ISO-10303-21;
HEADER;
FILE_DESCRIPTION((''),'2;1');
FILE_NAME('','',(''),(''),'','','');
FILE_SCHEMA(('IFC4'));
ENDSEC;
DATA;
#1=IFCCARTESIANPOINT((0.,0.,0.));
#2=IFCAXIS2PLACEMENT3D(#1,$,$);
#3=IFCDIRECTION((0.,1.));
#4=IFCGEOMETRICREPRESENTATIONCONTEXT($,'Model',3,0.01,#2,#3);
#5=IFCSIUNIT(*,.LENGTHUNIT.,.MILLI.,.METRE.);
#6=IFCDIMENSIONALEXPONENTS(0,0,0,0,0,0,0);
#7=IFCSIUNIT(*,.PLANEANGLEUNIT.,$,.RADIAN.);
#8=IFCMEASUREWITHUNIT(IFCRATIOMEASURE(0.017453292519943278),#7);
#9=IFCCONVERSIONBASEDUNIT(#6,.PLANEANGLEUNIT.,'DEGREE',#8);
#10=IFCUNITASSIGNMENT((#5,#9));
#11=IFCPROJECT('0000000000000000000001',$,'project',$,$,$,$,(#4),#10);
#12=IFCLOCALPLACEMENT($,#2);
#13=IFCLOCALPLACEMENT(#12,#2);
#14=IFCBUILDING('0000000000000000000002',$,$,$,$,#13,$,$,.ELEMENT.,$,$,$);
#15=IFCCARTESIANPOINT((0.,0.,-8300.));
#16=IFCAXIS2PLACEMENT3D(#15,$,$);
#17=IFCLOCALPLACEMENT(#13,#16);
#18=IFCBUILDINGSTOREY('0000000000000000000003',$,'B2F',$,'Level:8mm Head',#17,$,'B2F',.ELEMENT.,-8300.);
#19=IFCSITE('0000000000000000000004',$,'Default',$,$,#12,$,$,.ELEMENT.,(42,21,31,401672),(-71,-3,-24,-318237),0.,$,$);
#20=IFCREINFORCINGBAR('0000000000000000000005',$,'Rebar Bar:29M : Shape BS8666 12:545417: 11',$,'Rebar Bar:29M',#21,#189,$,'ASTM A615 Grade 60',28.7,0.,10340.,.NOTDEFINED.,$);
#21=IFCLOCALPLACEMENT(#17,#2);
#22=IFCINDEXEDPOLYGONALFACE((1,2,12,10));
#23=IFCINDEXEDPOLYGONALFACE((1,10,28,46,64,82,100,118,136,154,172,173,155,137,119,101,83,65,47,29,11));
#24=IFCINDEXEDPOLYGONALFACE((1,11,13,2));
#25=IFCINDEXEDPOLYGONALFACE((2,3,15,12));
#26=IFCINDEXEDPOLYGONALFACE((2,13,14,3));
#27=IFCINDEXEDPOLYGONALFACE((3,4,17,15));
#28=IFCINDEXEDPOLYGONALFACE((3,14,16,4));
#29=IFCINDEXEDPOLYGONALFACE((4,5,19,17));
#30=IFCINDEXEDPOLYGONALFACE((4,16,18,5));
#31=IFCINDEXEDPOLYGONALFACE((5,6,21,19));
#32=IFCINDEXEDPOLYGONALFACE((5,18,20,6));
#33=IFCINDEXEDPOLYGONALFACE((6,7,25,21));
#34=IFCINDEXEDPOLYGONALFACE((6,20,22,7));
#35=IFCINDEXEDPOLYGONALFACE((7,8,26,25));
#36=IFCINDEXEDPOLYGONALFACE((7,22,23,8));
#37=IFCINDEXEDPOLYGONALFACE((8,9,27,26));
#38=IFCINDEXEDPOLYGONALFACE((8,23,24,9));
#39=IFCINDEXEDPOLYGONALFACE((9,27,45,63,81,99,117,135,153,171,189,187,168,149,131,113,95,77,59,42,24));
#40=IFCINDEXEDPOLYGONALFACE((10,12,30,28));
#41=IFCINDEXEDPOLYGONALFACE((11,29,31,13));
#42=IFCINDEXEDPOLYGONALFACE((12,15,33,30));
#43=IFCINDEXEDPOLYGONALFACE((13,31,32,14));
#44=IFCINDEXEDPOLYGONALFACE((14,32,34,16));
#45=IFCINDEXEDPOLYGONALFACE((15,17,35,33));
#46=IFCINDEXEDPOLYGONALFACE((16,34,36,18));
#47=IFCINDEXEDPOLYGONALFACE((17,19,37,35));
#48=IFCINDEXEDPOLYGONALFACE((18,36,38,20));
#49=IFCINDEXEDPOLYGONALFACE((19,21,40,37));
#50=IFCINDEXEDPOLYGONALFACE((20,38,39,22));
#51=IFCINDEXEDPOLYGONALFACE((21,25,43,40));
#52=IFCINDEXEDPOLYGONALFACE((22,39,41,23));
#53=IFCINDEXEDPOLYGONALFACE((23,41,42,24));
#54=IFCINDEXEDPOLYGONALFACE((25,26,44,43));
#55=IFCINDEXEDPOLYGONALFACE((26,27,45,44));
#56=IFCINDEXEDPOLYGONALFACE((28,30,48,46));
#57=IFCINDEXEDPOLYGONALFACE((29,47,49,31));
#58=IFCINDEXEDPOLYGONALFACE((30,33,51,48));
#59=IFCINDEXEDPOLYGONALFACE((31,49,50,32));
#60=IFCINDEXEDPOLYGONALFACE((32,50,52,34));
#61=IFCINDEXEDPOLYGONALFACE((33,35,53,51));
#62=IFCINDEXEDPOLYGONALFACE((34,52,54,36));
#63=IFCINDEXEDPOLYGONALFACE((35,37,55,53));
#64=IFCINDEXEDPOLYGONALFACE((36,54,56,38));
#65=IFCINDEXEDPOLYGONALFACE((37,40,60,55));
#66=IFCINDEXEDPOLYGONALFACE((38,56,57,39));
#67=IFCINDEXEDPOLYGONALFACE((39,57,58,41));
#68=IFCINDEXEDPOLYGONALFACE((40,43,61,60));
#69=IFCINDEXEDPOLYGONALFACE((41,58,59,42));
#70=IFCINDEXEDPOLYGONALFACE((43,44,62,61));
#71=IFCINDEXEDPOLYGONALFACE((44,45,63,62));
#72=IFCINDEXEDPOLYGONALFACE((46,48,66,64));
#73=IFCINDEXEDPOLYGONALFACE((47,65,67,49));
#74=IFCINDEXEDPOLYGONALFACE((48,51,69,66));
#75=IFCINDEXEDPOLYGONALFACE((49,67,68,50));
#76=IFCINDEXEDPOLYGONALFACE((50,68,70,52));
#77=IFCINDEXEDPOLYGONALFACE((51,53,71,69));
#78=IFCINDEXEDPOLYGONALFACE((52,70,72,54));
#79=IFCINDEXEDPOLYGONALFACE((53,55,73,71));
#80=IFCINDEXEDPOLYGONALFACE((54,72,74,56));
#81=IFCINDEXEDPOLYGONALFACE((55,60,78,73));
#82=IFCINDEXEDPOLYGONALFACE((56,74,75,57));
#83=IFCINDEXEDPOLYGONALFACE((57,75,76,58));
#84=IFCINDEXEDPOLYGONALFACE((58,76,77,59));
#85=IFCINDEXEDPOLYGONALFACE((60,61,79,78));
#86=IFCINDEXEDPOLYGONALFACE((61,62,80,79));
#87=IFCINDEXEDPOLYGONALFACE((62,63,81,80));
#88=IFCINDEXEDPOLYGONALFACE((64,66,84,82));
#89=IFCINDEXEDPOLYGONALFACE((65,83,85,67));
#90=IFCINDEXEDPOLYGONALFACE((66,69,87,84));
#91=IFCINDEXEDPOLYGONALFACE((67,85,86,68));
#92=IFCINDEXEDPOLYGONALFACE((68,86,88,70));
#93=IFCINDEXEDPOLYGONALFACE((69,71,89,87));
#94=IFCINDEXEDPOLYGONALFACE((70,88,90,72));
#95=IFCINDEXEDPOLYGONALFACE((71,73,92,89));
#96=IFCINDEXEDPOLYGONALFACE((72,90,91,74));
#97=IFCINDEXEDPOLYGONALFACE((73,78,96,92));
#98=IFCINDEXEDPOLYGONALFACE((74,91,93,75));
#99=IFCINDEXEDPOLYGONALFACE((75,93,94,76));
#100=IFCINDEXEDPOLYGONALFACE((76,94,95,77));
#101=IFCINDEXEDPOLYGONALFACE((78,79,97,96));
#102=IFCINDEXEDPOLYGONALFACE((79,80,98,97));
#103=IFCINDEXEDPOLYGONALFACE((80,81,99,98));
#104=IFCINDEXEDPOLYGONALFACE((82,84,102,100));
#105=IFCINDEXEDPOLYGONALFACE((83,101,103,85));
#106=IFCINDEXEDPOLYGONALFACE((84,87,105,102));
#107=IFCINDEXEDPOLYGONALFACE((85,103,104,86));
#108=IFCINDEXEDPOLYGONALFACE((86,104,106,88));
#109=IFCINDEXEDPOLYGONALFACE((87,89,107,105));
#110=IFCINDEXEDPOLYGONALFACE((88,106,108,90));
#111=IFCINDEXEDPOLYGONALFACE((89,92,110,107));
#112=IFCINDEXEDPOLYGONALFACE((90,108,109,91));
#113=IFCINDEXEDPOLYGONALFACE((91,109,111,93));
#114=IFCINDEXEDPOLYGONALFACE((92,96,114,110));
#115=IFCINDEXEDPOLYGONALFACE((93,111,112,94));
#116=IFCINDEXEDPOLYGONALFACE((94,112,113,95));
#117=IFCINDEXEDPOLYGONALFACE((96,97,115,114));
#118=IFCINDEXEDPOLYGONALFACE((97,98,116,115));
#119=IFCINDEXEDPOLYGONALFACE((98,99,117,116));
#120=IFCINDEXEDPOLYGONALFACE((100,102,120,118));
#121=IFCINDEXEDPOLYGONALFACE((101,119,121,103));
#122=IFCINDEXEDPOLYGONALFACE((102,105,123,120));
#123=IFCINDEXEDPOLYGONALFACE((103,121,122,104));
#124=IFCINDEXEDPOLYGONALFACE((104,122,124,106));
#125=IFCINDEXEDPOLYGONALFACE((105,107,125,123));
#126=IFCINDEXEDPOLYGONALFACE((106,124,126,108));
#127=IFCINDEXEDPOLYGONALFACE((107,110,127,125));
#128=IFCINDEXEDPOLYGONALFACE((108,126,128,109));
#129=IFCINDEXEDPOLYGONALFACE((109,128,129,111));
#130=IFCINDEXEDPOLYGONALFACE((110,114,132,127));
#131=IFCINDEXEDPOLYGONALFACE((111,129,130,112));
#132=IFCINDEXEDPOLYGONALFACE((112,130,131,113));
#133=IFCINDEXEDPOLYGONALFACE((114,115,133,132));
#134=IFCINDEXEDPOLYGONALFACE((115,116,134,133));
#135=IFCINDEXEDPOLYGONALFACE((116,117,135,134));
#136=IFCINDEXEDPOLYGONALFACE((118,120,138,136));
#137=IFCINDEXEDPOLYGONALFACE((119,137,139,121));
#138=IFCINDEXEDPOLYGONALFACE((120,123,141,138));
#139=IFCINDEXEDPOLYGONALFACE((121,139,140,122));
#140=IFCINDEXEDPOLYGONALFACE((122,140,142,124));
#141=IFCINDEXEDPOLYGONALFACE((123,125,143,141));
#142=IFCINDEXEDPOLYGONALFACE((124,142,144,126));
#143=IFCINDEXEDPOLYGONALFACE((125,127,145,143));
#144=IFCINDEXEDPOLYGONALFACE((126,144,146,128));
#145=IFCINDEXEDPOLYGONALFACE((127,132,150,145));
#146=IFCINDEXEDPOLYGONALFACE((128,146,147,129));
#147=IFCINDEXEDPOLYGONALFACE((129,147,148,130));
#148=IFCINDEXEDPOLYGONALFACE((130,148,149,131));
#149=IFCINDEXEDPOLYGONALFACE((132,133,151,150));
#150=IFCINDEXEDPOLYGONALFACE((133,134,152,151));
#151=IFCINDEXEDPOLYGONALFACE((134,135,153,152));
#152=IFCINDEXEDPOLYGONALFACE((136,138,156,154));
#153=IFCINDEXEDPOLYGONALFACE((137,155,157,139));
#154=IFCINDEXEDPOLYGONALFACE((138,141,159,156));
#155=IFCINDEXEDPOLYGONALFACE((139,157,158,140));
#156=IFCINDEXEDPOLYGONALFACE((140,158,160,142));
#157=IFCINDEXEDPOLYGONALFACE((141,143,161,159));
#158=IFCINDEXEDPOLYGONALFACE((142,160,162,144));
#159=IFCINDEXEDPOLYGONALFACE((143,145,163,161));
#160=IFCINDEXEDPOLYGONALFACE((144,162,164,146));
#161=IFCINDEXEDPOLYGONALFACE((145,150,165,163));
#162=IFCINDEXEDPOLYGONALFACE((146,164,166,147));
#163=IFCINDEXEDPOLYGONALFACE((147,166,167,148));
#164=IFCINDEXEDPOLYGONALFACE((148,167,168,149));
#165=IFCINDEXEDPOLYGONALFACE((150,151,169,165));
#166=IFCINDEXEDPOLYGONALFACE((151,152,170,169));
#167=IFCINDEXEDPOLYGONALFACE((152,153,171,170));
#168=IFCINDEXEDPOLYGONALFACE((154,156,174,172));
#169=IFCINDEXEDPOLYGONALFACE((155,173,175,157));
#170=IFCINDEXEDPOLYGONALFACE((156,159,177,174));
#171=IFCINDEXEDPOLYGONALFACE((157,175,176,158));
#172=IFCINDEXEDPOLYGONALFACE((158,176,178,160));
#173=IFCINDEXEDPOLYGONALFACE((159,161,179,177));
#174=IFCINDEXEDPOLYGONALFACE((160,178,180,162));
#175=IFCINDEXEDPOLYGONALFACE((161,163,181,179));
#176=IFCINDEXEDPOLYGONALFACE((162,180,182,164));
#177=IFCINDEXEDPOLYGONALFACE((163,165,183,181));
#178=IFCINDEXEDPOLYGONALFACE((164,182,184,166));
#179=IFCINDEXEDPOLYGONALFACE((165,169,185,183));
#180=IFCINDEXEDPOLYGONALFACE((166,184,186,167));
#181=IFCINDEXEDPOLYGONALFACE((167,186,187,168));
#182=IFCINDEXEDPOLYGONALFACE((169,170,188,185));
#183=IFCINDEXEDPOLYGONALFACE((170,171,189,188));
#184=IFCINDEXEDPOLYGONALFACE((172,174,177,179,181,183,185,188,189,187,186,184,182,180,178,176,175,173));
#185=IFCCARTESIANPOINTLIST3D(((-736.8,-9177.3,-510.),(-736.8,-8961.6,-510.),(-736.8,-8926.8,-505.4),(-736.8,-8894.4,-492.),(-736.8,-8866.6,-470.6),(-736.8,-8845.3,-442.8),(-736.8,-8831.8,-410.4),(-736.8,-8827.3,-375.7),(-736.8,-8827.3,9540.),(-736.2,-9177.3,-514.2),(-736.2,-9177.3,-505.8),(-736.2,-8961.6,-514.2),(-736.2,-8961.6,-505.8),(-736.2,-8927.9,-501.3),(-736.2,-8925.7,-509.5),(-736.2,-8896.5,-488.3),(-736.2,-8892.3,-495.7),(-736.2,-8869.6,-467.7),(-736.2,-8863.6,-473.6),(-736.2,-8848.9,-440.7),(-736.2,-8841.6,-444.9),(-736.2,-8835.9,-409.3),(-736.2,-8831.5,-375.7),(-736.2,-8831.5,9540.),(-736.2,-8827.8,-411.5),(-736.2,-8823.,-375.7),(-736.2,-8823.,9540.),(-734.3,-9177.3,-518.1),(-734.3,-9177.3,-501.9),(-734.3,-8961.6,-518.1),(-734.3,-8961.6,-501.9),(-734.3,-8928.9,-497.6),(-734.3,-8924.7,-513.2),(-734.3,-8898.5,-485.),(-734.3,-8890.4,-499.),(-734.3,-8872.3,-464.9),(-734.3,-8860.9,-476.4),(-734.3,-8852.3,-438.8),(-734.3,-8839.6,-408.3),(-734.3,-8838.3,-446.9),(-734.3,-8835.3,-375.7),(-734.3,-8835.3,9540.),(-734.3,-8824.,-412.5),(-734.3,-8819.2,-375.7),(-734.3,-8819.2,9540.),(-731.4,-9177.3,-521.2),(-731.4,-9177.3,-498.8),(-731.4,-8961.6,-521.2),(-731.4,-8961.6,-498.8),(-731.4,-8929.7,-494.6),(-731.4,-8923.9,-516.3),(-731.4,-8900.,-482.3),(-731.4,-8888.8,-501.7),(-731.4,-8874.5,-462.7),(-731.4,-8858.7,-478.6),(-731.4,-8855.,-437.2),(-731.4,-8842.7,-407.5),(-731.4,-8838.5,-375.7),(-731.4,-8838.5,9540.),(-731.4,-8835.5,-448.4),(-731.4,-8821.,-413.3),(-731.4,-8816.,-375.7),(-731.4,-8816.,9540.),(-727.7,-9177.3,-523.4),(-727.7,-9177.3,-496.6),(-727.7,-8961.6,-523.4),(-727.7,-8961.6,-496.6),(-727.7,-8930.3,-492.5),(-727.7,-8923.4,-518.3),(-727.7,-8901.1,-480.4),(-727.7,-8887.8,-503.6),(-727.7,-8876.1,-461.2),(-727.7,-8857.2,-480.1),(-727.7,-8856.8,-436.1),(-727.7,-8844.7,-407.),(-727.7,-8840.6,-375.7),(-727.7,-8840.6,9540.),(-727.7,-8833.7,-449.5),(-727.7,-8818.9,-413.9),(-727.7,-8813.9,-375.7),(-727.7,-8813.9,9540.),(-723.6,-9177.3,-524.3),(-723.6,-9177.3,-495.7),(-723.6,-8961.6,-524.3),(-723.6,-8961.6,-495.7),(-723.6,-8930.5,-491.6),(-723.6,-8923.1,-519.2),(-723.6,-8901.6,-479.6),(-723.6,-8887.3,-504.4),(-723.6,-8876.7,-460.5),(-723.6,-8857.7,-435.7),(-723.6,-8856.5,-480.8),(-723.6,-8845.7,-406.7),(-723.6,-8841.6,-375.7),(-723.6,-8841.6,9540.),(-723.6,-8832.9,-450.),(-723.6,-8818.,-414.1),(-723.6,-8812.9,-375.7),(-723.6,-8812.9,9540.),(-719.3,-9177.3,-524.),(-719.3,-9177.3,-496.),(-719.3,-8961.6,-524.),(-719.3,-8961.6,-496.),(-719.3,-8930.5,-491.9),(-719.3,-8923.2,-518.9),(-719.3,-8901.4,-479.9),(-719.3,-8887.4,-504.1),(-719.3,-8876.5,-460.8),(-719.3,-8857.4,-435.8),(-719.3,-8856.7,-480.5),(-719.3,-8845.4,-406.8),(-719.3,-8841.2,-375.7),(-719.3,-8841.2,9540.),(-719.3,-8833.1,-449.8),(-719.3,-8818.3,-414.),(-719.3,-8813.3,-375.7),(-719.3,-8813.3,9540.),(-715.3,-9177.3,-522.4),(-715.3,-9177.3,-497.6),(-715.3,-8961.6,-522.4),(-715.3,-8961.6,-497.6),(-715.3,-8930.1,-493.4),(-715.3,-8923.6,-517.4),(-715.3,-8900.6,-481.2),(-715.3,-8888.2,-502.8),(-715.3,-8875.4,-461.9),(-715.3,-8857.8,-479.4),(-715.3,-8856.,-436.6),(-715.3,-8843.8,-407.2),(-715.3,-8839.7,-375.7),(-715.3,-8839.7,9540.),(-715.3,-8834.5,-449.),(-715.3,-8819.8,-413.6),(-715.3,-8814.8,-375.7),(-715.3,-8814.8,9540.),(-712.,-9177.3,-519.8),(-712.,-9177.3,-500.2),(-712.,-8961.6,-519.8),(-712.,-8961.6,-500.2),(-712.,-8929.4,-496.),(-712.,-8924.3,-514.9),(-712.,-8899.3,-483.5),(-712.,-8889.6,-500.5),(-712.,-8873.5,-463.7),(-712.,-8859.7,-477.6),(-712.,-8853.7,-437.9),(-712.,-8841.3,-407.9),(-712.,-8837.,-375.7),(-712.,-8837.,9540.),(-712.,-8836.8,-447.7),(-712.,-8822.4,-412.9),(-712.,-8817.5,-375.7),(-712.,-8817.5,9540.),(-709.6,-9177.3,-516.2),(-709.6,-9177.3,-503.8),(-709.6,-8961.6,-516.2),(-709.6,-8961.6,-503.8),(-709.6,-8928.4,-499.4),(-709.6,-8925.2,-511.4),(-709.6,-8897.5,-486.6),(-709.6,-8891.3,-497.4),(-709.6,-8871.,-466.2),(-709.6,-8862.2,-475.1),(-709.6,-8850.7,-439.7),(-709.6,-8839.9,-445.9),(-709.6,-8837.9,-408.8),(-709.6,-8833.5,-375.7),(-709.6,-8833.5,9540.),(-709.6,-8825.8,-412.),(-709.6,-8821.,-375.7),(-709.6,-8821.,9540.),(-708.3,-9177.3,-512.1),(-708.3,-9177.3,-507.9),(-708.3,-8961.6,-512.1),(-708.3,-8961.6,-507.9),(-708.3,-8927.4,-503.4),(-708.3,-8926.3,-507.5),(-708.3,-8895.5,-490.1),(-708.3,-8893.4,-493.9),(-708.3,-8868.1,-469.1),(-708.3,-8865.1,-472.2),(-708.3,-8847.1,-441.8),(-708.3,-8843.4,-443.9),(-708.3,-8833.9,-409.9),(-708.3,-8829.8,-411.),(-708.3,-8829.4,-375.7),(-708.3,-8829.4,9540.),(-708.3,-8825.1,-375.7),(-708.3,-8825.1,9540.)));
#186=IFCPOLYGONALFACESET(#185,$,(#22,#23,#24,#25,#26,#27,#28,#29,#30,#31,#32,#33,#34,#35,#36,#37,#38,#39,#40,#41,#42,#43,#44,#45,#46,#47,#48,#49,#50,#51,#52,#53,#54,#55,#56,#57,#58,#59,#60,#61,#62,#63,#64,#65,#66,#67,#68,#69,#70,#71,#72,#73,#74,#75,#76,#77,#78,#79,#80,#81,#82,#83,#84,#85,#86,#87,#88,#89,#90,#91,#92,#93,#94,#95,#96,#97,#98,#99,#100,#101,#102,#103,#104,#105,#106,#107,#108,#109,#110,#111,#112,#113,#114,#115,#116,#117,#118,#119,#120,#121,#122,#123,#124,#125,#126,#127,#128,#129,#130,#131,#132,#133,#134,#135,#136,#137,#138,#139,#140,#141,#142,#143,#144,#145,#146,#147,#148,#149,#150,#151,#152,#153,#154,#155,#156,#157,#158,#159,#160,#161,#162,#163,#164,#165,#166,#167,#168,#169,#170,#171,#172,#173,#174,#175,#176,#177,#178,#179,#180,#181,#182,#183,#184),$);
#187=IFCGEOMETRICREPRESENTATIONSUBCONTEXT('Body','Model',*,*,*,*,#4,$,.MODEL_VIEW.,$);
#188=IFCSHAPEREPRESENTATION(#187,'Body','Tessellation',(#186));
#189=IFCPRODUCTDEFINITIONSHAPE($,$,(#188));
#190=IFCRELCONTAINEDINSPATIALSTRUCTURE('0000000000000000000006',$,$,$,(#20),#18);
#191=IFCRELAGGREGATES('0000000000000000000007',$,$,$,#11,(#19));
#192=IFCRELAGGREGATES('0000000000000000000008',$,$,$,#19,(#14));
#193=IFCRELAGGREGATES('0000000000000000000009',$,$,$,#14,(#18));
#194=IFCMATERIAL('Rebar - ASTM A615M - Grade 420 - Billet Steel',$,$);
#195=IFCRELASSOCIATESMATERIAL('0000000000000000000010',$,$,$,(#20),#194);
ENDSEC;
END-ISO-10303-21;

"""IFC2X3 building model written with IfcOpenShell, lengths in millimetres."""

from ifc_helpers import new_model, entity, si_unit, converted_unit, direction, frame, origin, place, context, subcontext, project, spatial, material, element, save


model = new_model("IFC2X3")

# Units and contexts
model_context = context("Model", 3, precision=0.01, world=origin(), true_north=direction((0.0, 1.0)))
body_context = subcontext(model_context, "Body", "Model", "MODEL_VIEW")
ifc_project = project(units=[si_unit("LENGTHUNIT", "METRE", prefix="MILLI"), converted_unit("PLANEANGLEUNIT", "DEGREE", entity("IfcRatioMeasure", 0.017453292519943278), si_unit("PLANEANGLEUNIT", "RADIAN"), dimensions=[0, 0, 0, 0, 0, 0, 0])], contexts=[model_context])

# Site, building, storey
site_placement = place(None, origin())
site = spatial("IfcSite", under=ifc_project, at=site_placement, Name="Default", CompositionType="ELEMENT", RefLatitude=(42, 21, 31, 401672), RefLongitude=(-71, -3, -24, -318237), RefElevation=0.0)
building_placement = place(site_placement, origin())
building = spatial("IfcBuilding", under=site, at=building_placement, CompositionType="ELEMENT")
storey_placement = place(building_placement, frame((0.0, 0.0, -8300.0)))
storey = spatial("IfcBuildingStorey", under=building, at=storey_placement, Name="B2F", ObjectType="Level:8mm Head", LongName="B2F", CompositionType="ELEMENT", Elevation=-8300.0)

# Reinforcing bar
ifc_material_1 = material(Name="Rebar - ASTM A615M - Grade 420 - Billet Steel")
reinforcing_bar_1_placement = place(storey_placement, origin())
element("IfcReinforcingBar", 1, at=reinforcing_bar_1_placement, inside=storey, material=ifc_material_1, Name="Rebar Bar:29M : Shape BS8666 12:545417: 11", SteelGrade="ASTM A615 Grade 60", ObjectType="Rebar Bar:29M", BarLength=10340.0, BarRole="NOTDEFINED", CrossSectionArea=0.0, NominalDiameter=28.7, context=body_context, shape_type="AdvancedSweptSolid", body=[
    entity("IfcSweptDiskSolid", entity("IfcCompositeCurve", [entity("IfcCompositeCurveSegment", "CONTINUOUS", True, entity("IfcPolyline", [entity("IfcCartesianPoint", [-722.5, -8827.3, 9540.0]), entity("IfcCartesianPoint", [-722.5, -8827.3, -375.7])])), entity("IfcCompositeCurveSegment", "CONTINUOUS", True, entity("IfcTrimmedCurve", entity("IfcCircle", entity("IfcAxis2Placement3D", entity("IfcCartesianPoint", [-722.5, -8961.6, -375.7]), entity("IfcDirection", [-1.0, 0.0, 0.0]), entity("IfcDirection", [0.0, 0.0, -1.0])), 134.3), [entity("IfcParameterValue", 270.0)], [entity("IfcParameterValue", 360.0)], True, "PARAMETER")), entity("IfcCompositeCurveSegment", "CONTINUOUS", True, entity("IfcPolyline", [entity("IfcCartesianPoint", [-722.5, -8961.6, -510.0]), entity("IfcCartesianPoint", [-722.5, -9177.3, -510.0])]))], False), 14.3, None, 0.0, 92.0),
])

save(model, "model.ifc")
